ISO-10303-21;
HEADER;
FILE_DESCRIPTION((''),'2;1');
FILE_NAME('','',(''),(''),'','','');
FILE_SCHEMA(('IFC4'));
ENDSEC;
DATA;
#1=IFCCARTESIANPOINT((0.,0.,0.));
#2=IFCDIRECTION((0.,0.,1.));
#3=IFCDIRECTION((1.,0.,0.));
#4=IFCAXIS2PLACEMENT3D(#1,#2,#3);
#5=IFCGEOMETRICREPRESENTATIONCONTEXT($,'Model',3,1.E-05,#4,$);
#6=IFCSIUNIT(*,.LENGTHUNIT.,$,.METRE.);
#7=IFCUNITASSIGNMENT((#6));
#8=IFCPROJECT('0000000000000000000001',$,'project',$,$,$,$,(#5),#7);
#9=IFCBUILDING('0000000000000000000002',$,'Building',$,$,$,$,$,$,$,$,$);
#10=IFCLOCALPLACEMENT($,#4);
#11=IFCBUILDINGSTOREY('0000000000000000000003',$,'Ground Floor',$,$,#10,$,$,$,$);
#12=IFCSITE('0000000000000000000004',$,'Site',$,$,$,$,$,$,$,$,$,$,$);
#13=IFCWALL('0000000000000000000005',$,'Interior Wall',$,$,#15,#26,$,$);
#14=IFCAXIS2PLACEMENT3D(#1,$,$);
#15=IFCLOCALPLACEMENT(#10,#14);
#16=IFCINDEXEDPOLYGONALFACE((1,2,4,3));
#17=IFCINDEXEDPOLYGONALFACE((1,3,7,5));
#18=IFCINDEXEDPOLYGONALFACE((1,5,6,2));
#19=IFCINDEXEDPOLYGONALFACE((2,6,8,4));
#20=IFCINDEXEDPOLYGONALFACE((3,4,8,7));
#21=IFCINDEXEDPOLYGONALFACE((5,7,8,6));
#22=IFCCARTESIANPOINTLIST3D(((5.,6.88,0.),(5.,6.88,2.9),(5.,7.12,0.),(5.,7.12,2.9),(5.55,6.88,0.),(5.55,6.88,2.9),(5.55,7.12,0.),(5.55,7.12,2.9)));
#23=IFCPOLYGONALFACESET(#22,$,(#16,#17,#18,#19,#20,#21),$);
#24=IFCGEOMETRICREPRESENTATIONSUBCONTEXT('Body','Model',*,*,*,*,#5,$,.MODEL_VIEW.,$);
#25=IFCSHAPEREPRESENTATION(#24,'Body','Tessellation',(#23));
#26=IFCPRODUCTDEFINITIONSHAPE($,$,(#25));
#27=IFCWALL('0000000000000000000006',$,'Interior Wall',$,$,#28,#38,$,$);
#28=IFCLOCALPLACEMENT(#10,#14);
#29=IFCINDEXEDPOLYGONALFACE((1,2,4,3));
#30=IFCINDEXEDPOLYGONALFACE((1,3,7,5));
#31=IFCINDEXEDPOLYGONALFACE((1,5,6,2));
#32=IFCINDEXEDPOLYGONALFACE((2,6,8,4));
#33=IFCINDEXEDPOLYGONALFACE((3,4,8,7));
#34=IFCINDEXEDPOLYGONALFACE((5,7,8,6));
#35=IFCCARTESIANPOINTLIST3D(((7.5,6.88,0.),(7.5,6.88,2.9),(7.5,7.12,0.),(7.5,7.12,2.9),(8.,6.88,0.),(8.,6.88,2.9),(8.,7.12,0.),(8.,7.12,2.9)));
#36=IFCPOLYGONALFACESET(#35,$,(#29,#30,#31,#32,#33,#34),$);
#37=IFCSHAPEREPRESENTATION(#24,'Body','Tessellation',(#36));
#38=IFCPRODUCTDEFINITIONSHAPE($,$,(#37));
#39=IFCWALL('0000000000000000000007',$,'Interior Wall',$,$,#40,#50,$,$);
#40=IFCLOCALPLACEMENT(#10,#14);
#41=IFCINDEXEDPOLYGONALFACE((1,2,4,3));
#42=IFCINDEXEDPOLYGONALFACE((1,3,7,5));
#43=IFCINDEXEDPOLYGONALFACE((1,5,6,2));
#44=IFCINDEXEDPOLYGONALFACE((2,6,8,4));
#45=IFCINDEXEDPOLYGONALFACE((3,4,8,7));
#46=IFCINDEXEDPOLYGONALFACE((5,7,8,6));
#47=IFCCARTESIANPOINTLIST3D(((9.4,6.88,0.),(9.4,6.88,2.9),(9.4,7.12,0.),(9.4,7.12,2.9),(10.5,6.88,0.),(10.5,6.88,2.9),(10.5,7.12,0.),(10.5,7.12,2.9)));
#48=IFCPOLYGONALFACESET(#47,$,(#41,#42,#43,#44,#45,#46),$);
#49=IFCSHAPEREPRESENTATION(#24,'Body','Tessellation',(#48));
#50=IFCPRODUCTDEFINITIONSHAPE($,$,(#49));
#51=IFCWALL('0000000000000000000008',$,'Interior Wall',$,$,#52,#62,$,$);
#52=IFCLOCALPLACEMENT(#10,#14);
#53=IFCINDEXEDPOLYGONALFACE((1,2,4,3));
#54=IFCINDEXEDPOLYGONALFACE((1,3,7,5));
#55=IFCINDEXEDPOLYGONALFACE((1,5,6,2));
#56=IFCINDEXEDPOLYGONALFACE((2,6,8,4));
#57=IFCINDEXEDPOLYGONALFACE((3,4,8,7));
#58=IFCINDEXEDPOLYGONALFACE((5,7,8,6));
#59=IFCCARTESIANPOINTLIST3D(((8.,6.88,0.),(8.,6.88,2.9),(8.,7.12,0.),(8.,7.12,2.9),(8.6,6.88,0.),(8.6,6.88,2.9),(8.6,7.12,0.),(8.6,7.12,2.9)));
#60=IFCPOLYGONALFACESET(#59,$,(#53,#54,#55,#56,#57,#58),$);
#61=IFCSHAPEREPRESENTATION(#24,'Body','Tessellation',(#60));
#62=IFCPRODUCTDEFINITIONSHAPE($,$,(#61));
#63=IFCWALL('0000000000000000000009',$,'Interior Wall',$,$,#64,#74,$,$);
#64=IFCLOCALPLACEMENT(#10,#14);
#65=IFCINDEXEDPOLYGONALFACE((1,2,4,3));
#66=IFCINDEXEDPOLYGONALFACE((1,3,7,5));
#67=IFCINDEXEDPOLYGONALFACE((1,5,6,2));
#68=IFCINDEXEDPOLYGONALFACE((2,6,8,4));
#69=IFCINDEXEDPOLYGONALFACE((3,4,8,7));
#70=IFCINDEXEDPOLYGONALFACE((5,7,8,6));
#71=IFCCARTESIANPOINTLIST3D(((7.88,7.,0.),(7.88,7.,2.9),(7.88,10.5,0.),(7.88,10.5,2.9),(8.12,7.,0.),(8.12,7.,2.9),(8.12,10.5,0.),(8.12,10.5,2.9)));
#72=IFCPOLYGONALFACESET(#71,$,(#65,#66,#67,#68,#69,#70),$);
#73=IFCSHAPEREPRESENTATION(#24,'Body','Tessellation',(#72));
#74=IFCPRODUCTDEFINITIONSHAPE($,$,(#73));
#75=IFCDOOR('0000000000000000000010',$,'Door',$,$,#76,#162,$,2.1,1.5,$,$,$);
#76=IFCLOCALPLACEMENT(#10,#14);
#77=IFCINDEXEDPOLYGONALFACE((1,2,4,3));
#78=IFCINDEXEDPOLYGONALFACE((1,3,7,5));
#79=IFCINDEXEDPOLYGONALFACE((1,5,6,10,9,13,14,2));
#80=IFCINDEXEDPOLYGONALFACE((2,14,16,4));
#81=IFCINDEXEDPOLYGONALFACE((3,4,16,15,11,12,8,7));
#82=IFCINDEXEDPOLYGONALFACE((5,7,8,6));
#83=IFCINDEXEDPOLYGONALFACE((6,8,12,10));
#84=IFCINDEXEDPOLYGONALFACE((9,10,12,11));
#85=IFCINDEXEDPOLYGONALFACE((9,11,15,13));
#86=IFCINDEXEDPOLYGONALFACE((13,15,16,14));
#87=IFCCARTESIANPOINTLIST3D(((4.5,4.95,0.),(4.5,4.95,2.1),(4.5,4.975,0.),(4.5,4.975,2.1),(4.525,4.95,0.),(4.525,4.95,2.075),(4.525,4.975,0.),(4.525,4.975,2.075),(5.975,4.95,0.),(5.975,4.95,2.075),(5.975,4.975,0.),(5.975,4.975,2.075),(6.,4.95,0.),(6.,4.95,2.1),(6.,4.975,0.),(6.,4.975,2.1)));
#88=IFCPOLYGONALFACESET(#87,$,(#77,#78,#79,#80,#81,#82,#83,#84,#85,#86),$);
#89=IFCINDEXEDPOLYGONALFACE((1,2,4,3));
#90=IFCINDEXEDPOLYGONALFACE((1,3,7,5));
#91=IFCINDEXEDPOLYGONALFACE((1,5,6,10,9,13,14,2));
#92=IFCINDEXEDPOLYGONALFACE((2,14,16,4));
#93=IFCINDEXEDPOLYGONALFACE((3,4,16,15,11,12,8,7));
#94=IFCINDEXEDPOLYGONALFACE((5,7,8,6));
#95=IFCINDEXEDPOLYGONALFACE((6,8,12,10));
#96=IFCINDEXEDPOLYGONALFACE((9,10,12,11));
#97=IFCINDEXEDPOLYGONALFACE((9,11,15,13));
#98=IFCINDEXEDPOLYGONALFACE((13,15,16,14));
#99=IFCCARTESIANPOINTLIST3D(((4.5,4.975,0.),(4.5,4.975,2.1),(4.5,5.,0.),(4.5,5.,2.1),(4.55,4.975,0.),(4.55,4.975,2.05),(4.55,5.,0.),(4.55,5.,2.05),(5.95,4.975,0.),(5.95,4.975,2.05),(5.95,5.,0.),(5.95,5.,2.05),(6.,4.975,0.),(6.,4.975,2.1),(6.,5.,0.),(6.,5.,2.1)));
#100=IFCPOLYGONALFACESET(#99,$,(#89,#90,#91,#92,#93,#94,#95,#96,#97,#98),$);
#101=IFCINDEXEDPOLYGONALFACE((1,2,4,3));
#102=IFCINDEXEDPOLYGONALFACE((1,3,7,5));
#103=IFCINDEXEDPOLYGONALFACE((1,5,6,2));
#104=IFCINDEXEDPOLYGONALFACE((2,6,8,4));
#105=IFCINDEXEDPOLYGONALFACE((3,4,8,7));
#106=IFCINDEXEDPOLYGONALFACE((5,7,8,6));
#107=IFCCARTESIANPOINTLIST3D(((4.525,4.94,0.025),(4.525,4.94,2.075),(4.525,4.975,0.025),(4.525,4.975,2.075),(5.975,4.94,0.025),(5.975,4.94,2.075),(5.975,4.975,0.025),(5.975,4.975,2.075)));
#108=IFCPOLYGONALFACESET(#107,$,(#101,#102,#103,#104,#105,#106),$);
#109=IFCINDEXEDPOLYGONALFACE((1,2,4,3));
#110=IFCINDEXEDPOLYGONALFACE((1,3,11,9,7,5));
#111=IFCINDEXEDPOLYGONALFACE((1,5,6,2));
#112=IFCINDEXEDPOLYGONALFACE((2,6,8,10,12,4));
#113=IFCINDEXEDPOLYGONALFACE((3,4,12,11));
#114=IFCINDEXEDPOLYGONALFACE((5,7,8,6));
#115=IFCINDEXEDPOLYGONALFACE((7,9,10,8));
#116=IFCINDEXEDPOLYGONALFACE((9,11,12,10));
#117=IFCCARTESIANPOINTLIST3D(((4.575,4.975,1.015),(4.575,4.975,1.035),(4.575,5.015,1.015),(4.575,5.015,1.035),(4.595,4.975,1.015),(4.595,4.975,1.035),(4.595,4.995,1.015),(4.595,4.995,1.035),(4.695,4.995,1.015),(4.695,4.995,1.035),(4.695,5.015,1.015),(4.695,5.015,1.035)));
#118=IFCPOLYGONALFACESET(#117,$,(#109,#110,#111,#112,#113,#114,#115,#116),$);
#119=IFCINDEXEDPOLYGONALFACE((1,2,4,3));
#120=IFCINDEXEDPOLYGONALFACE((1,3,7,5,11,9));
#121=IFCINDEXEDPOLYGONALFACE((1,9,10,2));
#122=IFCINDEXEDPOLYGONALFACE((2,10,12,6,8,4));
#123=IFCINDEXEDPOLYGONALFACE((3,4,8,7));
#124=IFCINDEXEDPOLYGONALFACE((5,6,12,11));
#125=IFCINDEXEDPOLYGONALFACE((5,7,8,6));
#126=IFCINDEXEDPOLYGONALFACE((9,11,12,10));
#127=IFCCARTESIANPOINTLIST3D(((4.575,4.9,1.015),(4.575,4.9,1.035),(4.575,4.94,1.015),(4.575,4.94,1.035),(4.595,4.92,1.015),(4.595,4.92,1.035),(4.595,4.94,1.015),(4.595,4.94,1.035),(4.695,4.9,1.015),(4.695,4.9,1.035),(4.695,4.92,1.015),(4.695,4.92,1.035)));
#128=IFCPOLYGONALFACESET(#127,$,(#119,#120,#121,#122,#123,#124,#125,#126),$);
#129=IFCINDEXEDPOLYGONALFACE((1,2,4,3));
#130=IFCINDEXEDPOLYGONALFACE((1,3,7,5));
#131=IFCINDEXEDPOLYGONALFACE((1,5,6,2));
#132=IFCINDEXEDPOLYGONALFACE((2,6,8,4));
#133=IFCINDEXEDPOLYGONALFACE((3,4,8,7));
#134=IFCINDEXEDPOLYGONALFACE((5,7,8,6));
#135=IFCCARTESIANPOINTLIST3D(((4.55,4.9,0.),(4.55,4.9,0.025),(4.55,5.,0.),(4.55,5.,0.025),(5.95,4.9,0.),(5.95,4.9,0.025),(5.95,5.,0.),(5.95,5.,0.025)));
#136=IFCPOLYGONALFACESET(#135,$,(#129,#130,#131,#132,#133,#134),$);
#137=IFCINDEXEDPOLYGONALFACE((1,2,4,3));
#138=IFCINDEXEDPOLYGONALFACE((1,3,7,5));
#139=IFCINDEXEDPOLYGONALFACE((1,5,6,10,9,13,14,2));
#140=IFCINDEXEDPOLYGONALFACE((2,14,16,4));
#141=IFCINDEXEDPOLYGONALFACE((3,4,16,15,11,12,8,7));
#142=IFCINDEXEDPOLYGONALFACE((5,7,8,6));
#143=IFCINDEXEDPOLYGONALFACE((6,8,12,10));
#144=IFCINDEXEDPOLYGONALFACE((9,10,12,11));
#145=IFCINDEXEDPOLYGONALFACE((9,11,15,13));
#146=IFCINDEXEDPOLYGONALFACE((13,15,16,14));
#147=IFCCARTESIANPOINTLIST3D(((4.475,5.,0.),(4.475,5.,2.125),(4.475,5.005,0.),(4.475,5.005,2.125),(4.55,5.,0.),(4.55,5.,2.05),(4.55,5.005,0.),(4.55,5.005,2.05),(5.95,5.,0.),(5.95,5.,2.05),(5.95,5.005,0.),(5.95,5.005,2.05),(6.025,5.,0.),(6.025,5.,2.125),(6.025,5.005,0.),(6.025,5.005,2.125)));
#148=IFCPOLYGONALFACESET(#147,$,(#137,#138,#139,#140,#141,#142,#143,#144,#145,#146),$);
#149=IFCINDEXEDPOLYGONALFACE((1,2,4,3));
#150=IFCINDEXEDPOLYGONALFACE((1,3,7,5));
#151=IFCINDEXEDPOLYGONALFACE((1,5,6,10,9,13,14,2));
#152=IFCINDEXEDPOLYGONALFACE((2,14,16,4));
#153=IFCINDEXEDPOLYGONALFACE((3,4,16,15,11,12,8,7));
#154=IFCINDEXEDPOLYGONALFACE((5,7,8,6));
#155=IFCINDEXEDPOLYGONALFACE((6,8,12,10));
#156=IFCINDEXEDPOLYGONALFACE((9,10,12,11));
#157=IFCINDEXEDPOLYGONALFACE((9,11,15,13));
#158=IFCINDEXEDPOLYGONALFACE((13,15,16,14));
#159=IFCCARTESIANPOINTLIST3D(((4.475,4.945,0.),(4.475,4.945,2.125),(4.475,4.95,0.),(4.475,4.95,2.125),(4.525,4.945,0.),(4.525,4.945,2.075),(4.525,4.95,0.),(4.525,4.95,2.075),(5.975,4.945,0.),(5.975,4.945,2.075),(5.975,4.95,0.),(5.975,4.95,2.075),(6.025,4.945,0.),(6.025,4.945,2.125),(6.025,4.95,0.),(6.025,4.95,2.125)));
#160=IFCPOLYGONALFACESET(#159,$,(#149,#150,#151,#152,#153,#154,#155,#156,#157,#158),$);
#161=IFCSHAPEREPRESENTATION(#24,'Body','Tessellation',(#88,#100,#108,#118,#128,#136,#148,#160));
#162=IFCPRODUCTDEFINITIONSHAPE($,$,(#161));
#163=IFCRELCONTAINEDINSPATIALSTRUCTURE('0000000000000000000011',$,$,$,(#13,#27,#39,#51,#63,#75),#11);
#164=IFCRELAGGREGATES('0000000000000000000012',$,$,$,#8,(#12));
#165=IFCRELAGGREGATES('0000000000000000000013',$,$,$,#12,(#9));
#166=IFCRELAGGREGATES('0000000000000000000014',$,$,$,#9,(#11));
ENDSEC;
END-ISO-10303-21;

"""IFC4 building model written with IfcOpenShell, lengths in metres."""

from ifc_helpers import new_model, si_unit, frame, origin_with_axes, place, context, subcontext, project, spatial, line, indexed_curve, outline, extrude, element, save


model = new_model("IFC4")

# Units and contexts
model_context = context("Model", 3, precision=1e-05, world=origin_with_axes())
body_context = subcontext(model_context, "Body", "Model", "MODEL_VIEW")
ifc_project = project(units=[si_unit("LENGTHUNIT", "METRE")], contexts=[model_context])

# Site, building, storey
site = spatial("IfcSite", under=ifc_project, Name="Site")
building = spatial("IfcBuilding", under=site, Name="Building")
storey_placement = place(None, origin_with_axes())
storey = spatial("IfcBuildingStorey", under=building, at=storey_placement, Name="Ground Floor")

# Walls
wall_1_placement = place(storey_placement, frame((5.55, 7.0, 0.0), z_axis=(0.0, 0.0, 1.0), x_axis=(-1.0, 0.0, 0.0)))
element("IfcWall", 1, at=wall_1_placement, inside=storey, Name="Interior Wall", context=body_context, shape_type="SweptSolid", body=[
    extrude(outline(indexed_curve([(0.0, 0.0), (0.0, 0.24), (0.55, 0.24), (0.55, 0.0), (0.0, 0.0)], self_intersect=False)), frame((0.0, -0.12, 0.0), z_axis=(0.0, 0.0, 1.0), x_axis=(1.0, 0.0, 0.0)), (0.0, 0.0, 1.0), 2.9),
])
wall_2_placement = place(storey_placement, frame((8.0, 7.0, 0.0), z_axis=(0.0, 0.0, 1.0), x_axis=(-1.0, 0.0, 0.0)))
element("IfcWall", 2, at=wall_2_placement, inside=storey, Name="Interior Wall", context=body_context, shape_type="SweptSolid", body=[
    extrude(outline(indexed_curve([(0.0, 0.0), (0.0, 0.24), (0.5, 0.24), (0.5, 0.0), (0.0, 0.0)], self_intersect=False)), frame((0.0, -0.12, 0.0), z_axis=(0.0, 0.0, 1.0), x_axis=(1.0, 0.0, 0.0)), (0.0, 0.0, 1.0), 2.9),
])
wall_3_placement = place(storey_placement, frame((10.5, 7.0, 0.0), z_axis=(0.0, 0.0, 1.0), x_axis=(-1.0, 0.0, 0.0)))
element("IfcWall", 3, at=wall_3_placement, inside=storey, Name="Interior Wall", context=body_context, shape_type="SweptSolid", body=[
    extrude(outline(indexed_curve([(0.0, 0.0), (0.0, 0.24), (1.1, 0.24), (1.1, 0.0), (0.0, 0.0)], self_intersect=False)), frame((0.0, -0.12, 0.0), z_axis=(0.0, 0.0, 1.0), x_axis=(1.0, 0.0, 0.0)), (0.0, 0.0, 1.0), 2.9),
])
wall_4_placement = place(storey_placement, frame((8.6, 7.0, 0.0), z_axis=(0.0, 0.0, 1.0), x_axis=(-1.0, 0.0, 0.0)))
element("IfcWall", 4, at=wall_4_placement, inside=storey, Name="Interior Wall", context=body_context, shape_type="SweptSolid", body=[
    extrude(outline(indexed_curve([(0.0, 0.0), (0.0, 0.24), (0.6, 0.24), (0.6, 0.0), (0.0, 0.0)], self_intersect=False)), frame((0.0, -0.12, 0.0), z_axis=(0.0, 0.0, 1.0), x_axis=(1.0, 0.0, 0.0)), (0.0, 0.0, 1.0), 2.9),
])
wall_5_placement = place(storey_placement, frame((8.0, 7.0, 0.0), z_axis=(0.0, 0.0, 1.0), x_axis=(0.0, 1.0, 0.0)))
element("IfcWall", 5, at=wall_5_placement, inside=storey, Name="Interior Wall", context=body_context, shape_type="SweptSolid", body=[
    extrude(outline(indexed_curve([(0.0, 0.0), (0.0, 0.24), (3.5, 0.24), (3.5, 0.0), (0.0, 0.0)], self_intersect=False)), frame((0.0, -0.12, 0.0), z_axis=(0.0, 0.0, 1.0), x_axis=(1.0, 0.0, 0.0)), (0.0, 0.0, 1.0), 2.9),
])

# Door
door_1_placement = place(storey_placement, frame((6.0, 5.0, 0.0), z_axis=(0.0, 0.0, 1.0), x_axis=(-1.0, 0.0, 0.0)))
element("IfcDoor", 6, at=door_1_placement, inside=storey, Name="Door", OverallHeight=2.1, OverallWidth=1.5, context=body_context, shape_type="SweptSolid", body=[
    extrude(outline(indexed_curve([(0.0, 0.0), (0.0, 2.1), (1.5, 2.1), (1.5, 0.0), (1.475, 0.0), (1.475, 2.075), (0.025, 2.075), (0.025, 0.0)], segments=[line(1, 2, 3, 4, 5, 6, 7, 8, 1)])), frame((0.0, 0.025, 0.0), z_axis=(0.0, -1.0, 0.0), x_axis=(1.0, 0.0, 0.0)), (0.0, 0.0, -1.0), 0.025),
    extrude(outline(indexed_curve([(0.0, 0.0), (0.0, 2.1), (1.5, 2.1), (1.5, 0.0), (1.45, 0.0), (1.45, 2.05), (0.05, 2.05), (0.05, 0.0)], segments=[line(1, 2, 3, 4, 5, 6, 7, 8, 1)])), frame((0.0, 0.0, 0.0), z_axis=(0.0, -1.0, 0.0), x_axis=(1.0, 0.0, 0.0)), (0.0, 0.0, -1.0), 0.025),
    extrude(outline(indexed_curve([(0.0, 0.0), (1.45, 0.0), (1.45, 0.035), (0.0, 0.035)], segments=[line(1, 2, 3, 4, 1)])), frame((0.025, 0.025, 0.025), z_axis=(0.0, 0.0, 1.0), x_axis=(1.0, 0.0, 0.0)), (0.0, 0.0, 1.0), 2.05),
    extrude(outline(indexed_curve([(0.0, 0.0), (0.0, -0.04), (-0.12, -0.04), (-0.12, -0.02), (-0.02, -0.02), (-0.02, 0.0)], segments=[line(1, 2, 3, 4, 5, 6, 1)])), frame((1.425, 0.025, 1.015), z_axis=(0.0, 0.0, 1.0), x_axis=(1.0, 0.0, 0.0)), (0.0, 0.0, 1.0), 0.02),
    extrude(outline(indexed_curve([(0.0, 0.0), (0.0, 0.04), (-0.12, 0.04), (-0.12, 0.02), (-0.02, 0.02), (-0.02, 0.0)], segments=[line(1, 2, 3, 4, 5, 6, 1)])), frame((1.425, 0.06, 1.015), z_axis=(0.0, 0.0, 1.0), x_axis=(1.0, 0.0, 0.0)), (0.0, 0.0, 1.0), 0.02),
    extrude(outline(indexed_curve([(0.0, 0.0), (1.4, 0.0), (1.4, 0.1), (0.0, 0.1)], segments=[line(1, 2, 3, 4, 1)])), frame((0.05, 0.0, 0.0), z_axis=(0.0, 0.0, 1.0), x_axis=(1.0, 0.0, 0.0)), (0.0, 0.0, 1.0), 0.025),
    extrude(outline(indexed_curve([(0.0, 0.0), (0.0, 2.125), (1.55, 2.125), (1.55, 0.0), (1.475, 0.0), (1.475, 2.05), (0.075, 2.05), (0.075, 0.0)], segments=[line(1, 2, 3, 4, 5, 6, 7, 8, 1)])), frame((-0.025, -0.005, 0.0), z_axis=(0.0, -1.0, 0.0), x_axis=(1.0, 0.0, 0.0)), (0.0, 0.0, -1.0), 0.005),
    extrude(outline(indexed_curve([(0.0, 0.0), (0.0, 2.125), (1.55, 2.125), (1.55, 0.0), (1.5, 0.0), (1.5, 2.075), (0.05, 2.075), (0.05, 0.0)], segments=[line(1, 2, 3, 4, 5, 6, 7, 8, 1)])), frame((-0.025, 0.05, 0.0), z_axis=(0.0, -1.0, 0.0), x_axis=(1.0, 0.0, 0.0)), (0.0, 0.0, -1.0), 0.005),
])

save(model, "model.ifc")
